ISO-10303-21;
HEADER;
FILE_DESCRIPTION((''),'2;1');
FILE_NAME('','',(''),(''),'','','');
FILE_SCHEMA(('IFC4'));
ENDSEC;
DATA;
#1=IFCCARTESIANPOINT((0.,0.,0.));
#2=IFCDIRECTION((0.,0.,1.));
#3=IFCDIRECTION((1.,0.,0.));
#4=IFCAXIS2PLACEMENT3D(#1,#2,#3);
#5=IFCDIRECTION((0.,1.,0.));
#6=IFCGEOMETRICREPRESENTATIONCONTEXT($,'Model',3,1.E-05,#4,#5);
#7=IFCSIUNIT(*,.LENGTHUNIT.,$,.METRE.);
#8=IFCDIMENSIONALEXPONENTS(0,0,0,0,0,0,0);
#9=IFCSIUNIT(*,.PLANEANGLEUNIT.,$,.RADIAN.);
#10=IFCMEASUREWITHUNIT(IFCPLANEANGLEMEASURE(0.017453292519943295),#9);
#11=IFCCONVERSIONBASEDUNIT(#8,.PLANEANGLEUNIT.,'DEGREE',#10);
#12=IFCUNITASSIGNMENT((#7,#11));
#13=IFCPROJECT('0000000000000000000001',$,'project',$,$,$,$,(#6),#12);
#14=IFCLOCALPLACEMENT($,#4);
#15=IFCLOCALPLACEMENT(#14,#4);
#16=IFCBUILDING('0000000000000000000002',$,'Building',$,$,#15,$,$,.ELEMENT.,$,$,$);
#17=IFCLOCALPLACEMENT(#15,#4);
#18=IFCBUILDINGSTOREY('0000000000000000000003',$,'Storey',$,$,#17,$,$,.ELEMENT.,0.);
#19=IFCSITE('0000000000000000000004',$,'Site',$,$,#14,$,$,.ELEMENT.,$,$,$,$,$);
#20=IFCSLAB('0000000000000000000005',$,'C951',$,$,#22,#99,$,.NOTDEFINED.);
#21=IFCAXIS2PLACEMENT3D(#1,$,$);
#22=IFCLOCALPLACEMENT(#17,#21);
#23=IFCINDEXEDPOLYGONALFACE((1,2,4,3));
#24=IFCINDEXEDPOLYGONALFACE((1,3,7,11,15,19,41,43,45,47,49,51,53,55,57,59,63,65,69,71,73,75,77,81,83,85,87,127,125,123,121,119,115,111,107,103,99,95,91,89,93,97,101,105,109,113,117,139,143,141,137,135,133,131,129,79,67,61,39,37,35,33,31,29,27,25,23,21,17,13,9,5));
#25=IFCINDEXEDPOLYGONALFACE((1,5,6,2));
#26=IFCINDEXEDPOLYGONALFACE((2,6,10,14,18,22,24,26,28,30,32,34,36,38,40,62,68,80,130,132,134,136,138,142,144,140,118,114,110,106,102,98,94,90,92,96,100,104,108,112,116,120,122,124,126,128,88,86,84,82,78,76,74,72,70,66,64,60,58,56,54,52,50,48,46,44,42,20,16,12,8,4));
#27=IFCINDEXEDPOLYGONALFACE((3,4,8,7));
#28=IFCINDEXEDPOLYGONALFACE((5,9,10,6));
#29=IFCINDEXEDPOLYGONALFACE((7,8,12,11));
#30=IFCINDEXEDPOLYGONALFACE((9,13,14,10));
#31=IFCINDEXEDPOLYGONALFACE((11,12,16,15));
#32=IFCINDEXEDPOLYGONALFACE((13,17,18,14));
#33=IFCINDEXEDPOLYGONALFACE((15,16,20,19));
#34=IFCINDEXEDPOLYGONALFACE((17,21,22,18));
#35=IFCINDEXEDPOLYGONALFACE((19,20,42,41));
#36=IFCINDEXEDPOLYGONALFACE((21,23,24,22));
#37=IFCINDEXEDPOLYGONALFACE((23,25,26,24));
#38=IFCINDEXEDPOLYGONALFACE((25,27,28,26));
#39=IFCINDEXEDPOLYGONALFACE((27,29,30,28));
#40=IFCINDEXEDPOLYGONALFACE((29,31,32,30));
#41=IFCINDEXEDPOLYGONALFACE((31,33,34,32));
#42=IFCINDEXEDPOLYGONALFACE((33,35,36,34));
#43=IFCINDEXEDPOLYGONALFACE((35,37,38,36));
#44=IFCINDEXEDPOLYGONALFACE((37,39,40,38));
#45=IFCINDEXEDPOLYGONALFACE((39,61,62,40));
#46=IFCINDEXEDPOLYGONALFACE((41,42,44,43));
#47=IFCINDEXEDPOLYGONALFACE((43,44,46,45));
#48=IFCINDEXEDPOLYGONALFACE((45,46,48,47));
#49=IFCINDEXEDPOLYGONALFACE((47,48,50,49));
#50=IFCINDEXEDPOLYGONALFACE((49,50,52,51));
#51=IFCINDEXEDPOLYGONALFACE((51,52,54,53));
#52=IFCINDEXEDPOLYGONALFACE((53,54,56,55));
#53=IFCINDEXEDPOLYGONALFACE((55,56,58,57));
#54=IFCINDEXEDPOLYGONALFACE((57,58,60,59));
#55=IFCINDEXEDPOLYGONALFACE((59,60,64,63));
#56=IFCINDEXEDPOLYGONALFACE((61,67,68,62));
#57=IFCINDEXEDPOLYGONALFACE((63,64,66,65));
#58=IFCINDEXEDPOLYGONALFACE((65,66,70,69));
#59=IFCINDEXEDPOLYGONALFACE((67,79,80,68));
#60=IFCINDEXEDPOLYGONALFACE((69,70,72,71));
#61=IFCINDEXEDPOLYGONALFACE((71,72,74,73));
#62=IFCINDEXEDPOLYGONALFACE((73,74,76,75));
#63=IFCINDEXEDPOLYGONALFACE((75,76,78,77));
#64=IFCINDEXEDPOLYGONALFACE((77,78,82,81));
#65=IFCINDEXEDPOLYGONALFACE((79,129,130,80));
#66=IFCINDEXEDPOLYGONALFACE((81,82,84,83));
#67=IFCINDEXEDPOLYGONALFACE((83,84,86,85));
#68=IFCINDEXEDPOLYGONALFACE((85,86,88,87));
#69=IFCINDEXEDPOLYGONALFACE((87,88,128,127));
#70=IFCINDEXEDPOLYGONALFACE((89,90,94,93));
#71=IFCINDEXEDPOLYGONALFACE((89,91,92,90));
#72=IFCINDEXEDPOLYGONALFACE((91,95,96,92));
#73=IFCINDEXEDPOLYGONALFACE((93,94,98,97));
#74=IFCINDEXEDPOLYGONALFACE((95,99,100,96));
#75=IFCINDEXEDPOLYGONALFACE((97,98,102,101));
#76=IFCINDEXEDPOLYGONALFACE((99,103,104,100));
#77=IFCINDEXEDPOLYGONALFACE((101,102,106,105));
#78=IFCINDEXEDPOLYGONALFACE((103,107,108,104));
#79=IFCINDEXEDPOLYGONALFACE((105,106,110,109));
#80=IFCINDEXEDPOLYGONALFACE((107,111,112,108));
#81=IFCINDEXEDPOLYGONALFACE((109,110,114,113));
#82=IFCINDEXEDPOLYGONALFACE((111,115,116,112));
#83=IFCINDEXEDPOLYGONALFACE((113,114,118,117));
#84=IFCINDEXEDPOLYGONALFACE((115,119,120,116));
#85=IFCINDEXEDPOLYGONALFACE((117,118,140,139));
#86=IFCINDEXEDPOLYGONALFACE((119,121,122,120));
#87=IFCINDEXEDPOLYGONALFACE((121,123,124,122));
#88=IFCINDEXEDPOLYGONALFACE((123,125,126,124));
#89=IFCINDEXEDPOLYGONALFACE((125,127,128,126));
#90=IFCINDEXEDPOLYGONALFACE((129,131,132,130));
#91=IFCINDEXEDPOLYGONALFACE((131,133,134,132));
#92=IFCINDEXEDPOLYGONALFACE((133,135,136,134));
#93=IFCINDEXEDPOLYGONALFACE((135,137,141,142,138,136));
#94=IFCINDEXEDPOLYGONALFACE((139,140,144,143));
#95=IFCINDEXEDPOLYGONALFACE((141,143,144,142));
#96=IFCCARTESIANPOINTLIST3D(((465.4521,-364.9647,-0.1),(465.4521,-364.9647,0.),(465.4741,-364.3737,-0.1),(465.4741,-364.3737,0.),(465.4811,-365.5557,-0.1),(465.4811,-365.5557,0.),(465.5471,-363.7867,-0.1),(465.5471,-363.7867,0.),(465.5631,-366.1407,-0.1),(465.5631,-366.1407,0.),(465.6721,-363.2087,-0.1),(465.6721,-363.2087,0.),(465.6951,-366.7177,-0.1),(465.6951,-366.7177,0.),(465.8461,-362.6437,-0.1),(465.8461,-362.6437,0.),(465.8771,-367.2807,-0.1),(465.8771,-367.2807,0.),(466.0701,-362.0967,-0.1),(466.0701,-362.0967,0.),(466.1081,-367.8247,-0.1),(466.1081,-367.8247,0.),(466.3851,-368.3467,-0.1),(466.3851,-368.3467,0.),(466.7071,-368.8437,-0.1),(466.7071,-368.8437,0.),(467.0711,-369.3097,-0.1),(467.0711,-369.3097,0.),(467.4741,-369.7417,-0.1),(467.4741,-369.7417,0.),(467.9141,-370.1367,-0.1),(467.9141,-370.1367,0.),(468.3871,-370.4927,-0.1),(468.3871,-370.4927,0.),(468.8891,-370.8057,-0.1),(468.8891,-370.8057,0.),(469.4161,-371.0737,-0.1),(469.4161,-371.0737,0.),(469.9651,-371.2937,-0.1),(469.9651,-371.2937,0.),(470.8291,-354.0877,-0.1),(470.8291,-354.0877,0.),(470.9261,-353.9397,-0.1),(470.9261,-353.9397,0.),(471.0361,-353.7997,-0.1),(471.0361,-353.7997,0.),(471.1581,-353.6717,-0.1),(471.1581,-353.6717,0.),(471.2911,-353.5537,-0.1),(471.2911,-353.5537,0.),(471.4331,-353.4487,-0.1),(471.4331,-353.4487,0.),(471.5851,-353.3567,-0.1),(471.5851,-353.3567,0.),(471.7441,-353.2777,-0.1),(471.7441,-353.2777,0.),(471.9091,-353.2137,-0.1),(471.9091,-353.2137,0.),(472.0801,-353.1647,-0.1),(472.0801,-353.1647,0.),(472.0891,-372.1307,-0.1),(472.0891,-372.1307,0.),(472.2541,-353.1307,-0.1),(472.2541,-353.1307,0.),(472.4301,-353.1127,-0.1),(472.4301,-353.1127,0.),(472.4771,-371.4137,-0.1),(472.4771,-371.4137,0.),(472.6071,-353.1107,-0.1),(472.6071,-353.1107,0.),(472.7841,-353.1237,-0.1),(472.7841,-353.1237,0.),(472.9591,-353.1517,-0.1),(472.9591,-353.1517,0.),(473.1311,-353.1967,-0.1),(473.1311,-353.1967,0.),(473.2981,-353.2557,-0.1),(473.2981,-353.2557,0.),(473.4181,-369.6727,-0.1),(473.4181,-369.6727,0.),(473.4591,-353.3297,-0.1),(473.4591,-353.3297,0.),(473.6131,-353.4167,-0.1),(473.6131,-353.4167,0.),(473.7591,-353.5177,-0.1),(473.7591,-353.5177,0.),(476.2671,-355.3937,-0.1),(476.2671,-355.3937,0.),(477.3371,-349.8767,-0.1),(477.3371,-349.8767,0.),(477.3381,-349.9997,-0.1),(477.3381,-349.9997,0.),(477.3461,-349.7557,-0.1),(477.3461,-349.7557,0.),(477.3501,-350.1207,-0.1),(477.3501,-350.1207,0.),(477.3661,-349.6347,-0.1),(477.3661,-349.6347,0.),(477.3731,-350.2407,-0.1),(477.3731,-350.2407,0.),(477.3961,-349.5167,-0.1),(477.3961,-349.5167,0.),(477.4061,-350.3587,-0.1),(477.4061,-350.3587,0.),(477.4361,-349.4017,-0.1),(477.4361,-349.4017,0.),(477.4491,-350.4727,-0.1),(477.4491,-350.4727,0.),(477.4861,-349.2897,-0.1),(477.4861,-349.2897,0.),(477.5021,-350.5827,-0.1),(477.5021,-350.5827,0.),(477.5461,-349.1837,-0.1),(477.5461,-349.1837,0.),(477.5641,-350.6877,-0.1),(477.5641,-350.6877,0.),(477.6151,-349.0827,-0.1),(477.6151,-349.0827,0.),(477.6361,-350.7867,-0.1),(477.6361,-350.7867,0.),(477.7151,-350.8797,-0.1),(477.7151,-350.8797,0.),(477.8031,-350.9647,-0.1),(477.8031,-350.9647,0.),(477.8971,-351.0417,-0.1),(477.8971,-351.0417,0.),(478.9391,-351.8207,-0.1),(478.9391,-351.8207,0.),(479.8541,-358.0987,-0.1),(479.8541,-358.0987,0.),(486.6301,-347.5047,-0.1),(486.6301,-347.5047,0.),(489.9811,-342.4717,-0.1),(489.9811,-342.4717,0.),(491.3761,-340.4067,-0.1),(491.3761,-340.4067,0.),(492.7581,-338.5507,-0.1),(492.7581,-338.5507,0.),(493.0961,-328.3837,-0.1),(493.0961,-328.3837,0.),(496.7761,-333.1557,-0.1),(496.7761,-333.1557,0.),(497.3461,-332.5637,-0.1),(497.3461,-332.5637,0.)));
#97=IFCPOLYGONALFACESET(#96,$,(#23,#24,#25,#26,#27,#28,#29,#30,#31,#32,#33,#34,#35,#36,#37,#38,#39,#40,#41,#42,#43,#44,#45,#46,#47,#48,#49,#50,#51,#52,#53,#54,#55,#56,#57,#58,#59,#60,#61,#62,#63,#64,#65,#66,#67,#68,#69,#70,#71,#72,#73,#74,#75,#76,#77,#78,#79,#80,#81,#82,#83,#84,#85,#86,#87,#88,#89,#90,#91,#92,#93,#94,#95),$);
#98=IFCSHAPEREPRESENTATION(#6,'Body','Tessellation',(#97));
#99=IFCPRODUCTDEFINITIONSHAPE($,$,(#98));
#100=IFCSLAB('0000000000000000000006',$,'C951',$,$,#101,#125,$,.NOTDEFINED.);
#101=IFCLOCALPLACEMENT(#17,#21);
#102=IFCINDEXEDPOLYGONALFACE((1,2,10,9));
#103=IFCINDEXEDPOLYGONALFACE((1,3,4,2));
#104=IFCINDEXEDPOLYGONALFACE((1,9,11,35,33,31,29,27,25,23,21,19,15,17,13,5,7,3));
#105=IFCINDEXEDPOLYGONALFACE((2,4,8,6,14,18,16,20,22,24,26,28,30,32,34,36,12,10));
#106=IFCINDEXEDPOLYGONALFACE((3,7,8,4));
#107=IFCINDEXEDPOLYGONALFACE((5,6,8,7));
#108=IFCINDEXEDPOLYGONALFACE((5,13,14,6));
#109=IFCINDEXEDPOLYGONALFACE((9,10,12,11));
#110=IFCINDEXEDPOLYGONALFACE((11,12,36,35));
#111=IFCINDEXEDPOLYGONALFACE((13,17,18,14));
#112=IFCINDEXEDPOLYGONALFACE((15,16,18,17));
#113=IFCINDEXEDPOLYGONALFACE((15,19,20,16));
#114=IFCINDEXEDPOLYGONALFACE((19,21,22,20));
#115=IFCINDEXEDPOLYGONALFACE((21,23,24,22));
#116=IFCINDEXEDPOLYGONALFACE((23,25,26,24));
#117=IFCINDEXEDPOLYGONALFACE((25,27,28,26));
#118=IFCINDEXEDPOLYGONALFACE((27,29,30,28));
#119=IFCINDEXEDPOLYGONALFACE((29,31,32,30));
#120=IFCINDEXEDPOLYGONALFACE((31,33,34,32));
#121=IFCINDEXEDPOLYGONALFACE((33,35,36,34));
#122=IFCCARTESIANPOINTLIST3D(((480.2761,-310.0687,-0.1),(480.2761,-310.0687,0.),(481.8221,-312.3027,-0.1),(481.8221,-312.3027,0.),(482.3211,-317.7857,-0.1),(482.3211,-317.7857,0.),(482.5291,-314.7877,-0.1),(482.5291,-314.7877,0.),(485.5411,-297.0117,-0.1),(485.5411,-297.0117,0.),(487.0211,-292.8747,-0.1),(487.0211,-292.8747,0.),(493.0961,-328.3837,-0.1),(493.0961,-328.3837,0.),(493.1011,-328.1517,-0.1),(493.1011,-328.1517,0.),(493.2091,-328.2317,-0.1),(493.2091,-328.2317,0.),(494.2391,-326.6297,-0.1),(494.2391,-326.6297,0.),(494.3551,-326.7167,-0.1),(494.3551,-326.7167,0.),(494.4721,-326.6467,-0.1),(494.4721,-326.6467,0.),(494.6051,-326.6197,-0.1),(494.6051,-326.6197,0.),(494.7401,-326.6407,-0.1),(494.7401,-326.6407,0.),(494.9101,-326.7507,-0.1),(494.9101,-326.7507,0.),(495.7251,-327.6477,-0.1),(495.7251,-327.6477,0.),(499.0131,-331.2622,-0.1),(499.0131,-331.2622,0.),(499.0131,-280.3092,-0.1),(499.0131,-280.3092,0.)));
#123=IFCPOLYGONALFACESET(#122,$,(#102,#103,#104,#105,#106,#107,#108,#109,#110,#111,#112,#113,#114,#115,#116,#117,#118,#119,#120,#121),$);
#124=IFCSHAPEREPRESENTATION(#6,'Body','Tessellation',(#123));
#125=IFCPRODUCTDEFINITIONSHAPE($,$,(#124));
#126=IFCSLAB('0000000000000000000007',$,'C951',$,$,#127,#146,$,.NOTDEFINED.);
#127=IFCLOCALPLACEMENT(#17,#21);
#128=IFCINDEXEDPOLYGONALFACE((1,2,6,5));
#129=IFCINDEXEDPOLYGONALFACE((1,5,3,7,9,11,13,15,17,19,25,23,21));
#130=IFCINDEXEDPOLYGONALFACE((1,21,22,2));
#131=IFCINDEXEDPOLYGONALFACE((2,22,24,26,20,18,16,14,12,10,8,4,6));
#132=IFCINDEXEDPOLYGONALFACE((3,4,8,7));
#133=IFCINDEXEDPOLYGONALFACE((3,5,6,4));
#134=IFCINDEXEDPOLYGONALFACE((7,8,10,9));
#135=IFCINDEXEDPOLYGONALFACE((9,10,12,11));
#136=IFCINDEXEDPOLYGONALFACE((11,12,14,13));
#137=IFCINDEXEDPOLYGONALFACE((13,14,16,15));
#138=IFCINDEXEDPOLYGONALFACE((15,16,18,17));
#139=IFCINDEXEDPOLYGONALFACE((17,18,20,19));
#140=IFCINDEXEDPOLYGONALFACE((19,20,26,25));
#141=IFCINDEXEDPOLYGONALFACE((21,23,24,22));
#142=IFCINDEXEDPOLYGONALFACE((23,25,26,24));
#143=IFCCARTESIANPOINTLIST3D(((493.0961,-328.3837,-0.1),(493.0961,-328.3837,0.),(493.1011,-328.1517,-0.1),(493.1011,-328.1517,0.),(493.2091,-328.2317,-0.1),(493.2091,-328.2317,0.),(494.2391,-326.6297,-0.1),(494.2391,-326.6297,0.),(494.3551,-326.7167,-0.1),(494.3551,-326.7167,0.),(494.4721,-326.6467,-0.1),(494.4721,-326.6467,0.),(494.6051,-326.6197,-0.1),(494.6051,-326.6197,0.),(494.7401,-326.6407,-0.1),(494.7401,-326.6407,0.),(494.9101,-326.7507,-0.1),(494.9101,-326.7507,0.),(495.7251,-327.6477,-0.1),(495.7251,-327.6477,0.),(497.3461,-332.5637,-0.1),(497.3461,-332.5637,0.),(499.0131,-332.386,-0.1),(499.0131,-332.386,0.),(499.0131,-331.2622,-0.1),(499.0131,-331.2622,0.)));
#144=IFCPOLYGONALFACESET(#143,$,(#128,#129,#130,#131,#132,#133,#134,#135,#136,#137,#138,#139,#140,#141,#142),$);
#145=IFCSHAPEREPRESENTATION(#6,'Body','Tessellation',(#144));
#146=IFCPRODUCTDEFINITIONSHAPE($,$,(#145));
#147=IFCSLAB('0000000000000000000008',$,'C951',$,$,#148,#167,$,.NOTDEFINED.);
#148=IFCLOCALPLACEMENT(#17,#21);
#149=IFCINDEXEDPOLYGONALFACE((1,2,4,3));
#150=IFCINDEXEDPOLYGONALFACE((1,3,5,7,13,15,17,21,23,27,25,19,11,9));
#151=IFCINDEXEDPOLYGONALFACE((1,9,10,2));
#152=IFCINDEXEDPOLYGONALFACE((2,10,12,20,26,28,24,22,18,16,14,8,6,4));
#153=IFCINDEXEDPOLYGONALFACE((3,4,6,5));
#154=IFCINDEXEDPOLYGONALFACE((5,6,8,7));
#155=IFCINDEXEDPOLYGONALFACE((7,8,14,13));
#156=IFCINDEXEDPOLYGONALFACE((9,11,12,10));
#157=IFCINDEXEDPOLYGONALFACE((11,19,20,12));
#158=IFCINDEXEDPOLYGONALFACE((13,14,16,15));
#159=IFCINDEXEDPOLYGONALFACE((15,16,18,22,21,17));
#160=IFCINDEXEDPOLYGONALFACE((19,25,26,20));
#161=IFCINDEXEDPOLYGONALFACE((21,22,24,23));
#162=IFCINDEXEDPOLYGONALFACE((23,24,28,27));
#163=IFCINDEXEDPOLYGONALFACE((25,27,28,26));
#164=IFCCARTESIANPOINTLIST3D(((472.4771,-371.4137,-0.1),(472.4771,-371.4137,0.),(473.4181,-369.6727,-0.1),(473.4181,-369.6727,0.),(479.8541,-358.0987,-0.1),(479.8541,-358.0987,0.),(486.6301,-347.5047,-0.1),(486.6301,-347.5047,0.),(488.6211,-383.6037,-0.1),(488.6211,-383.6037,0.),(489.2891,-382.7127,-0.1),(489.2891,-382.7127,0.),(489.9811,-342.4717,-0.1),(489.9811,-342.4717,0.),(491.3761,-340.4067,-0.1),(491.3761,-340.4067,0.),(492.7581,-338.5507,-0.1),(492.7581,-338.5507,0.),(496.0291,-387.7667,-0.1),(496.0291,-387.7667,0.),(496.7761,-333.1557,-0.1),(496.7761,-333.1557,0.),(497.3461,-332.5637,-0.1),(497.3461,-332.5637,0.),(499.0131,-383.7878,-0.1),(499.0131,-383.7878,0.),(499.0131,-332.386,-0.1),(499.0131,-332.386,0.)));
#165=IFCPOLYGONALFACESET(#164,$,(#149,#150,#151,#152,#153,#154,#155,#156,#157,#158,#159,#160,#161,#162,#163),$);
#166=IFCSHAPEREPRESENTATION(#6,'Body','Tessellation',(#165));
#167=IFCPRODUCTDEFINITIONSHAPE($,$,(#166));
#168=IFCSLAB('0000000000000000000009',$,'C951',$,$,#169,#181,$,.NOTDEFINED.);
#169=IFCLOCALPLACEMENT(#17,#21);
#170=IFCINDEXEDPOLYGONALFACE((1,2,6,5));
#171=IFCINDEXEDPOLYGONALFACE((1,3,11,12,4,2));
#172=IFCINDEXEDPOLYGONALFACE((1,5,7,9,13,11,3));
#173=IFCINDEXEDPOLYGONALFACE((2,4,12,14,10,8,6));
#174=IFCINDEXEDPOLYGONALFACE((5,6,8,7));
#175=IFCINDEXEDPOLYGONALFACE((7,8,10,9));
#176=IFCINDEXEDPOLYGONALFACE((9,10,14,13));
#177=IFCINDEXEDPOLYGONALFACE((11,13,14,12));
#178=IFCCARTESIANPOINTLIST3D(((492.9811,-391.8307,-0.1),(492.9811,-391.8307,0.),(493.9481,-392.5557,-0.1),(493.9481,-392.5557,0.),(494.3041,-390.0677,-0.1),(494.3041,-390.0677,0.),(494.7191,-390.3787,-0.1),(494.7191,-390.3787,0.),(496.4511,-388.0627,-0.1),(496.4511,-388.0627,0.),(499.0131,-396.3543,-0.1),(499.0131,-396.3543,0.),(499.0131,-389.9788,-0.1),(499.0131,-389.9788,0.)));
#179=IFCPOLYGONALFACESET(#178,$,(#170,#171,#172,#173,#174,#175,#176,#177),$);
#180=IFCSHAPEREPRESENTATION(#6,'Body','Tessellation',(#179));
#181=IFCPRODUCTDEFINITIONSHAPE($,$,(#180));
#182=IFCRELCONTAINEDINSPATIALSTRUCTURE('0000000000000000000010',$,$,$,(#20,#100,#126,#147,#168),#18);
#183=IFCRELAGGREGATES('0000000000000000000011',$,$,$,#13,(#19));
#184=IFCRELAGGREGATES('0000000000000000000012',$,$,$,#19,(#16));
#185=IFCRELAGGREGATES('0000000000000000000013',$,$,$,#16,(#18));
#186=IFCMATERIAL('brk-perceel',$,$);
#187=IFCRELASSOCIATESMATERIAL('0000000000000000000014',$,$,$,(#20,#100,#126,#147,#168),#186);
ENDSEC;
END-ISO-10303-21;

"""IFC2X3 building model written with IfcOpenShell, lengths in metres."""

from ifc_helpers import new_model, entity, si_unit, converted_unit, direction, frame, origin_with_axes, place, context, project, spatial, polyline, outline, extrude, material, element, save


model = new_model("IFC2X3")

# Units and contexts
model_context = context("Model", 3, precision=1e-05, world=origin_with_axes(), true_north=direction((0.0, 1.0, 0.0)))
ifc_project = project(units=[si_unit("LENGTHUNIT", "METRE"), converted_unit("PLANEANGLEUNIT", "DEGREE", entity("IfcPlaneAngleMeasure", 0.017453292519943295), si_unit("PLANEANGLEUNIT", "RADIAN"), dimensions=[0, 0, 0, 0, 0, 0, 0])], contexts=[model_context])

# Site, building, storey
site_placement = place(None, origin_with_axes())
site = spatial("IfcSite", under=ifc_project, at=site_placement, Name="Site", CompositionType="ELEMENT")
building_placement = place(site_placement, origin_with_axes())
building = spatial("IfcBuilding", under=site, at=building_placement, Name="Building", CompositionType="ELEMENT")
storey_placement = place(building_placement, origin_with_axes())
storey = spatial("IfcBuildingStorey", under=building, at=storey_placement, Name="Storey", CompositionType="ELEMENT", Elevation=0.0)

# Slabs
ifc_material = material(Name="brk-perceel")
slab_1_placement = place(storey_placement, frame((0.0, 0.0, -0.1), z_axis=(0.0, 0.0, 1.0), x_axis=(1.0, 0.0, 0.0)))
element("IfcSlab", 1, at=slab_1_placement, inside=storey, material=ifc_material, Name="C951", PredefinedType="NOTDEFINED", context=model_context, shape_type="SweptSolid", body=[
    extrude(outline(polyline([(472.0891, -372.1307), (469.9651, -371.2937), (469.4161, -371.0737), (468.8891, -370.8057), (468.3871, -370.4927), (467.9141, -370.1367), (467.4741, -369.7417), (467.0711, -369.3097), (466.7071, -368.8437), (466.3851, -368.3467), (466.1081, -367.8247), (465.8771, -367.2807), (465.6951, -366.7177), (465.5631, -366.1407), (465.4811, -365.5557), (465.4521, -364.9647), (465.4741, -364.3737), (465.5471, -363.7867), (465.6721, -363.2087), (465.8461, -362.6437), (466.0701, -362.0967), (470.8291, -354.0877), (470.9261, -353.9397), (471.0361, -353.7997), (471.1581, -353.6717), (471.2911, -353.5537), (471.4331, -353.4487), (471.5851, -353.3567), (471.7441, -353.2777), (471.9091, -353.2137), (472.0801, -353.1647), (472.2541, -353.1307), (472.4301, -353.1127), (472.6071, -353.1107), (472.7841, -353.1237), (472.9591, -353.1517), (473.1311, -353.1967), (473.2981, -353.2557), (473.4591, -353.3297), (473.6131, -353.4167), (473.7591, -353.5177), (476.2671, -355.3937), (478.9391, -351.8207), (477.8971, -351.0417), (477.8031, -350.9647), (477.7151, -350.8797), (477.6361, -350.7867), (477.5641, -350.6877), (477.5021, -350.5827), (477.4491, -350.4727), (477.4061, -350.3587), (477.3731, -350.2407), (477.3501, -350.1207), (477.3381, -349.9997), (477.3371, -349.8767), (477.3461, -349.7557), (477.3661, -349.6347), (477.3961, -349.5167), (477.4361, -349.4017), (477.4861, -349.2897), (477.5461, -349.1837), (477.6151, -349.0827), (493.0961, -328.3837), (497.3461, -332.5637), (496.7761, -333.1557), (492.7581, -338.5507), (491.3761, -340.4067), (489.9811, -342.4717), (486.6301, -347.5047), (479.8541, -358.0987), (473.4181, -369.6727), (472.4771, -371.4137), (472.0891, -372.1307)])), origin_with_axes(), (0.0, 0.0, 1.0), 0.1),
])
slab_2_placement = place(storey_placement, frame((0.0, 0.0, -0.1), z_axis=(0.0, 0.0, 1.0), x_axis=(1.0, 0.0, 0.0)))
element("IfcSlab", 2, at=slab_2_placement, inside=storey, material=ifc_material, Name="C951", PredefinedType="NOTDEFINED", context=model_context, shape_type="SweptSolid", body=[
    extrude(outline(polyline([(495.7251, -327.6477), (494.9101, -326.7507), (494.7401, -326.6407), (494.6051, -326.6197), (494.4721, -326.6467), (494.3551, -326.7167), (494.2391, -326.6297), (493.1011, -328.1517), (493.2091, -328.2317), (493.0961, -328.3837), (482.3211, -317.7857), (482.5291, -314.7877), (481.8221, -312.3027), (480.2761, -310.0687), (485.5411, -297.0117), (487.0211, -292.8747), (499.0131, -280.3092), (499.0131, -331.2622), (495.7251, -327.6477)])), origin_with_axes(), (0.0, 0.0, 1.0), 0.1),
])
slab_3_placement = place(storey_placement, frame((0.0, 0.0, -0.1), z_axis=(0.0, 0.0, 1.0), x_axis=(1.0, 0.0, 0.0)))
element("IfcSlab", 3, at=slab_3_placement, inside=storey, material=ifc_material, Name="C951", PredefinedType="NOTDEFINED", context=model_context, shape_type="SweptSolid", body=[
    extrude(outline(polyline([(497.3461, -332.5637), (493.0961, -328.3837), (493.2091, -328.2317), (493.1011, -328.1517), (494.2391, -326.6297), (494.3551, -326.7167), (494.4721, -326.6467), (494.6051, -326.6197), (494.7401, -326.6407), (494.9101, -326.7507), (495.7251, -327.6477), (499.0131, -331.2622), (499.0131, -332.386), (497.3461, -332.5637)])), origin_with_axes(), (0.0, 0.0, 1.0), 0.1),
])
slab_4_placement = place(storey_placement, frame((0.0, 0.0, -0.1), z_axis=(0.0, 0.0, 1.0), x_axis=(1.0, 0.0, 0.0)))
element("IfcSlab", 4, at=slab_4_placement, inside=storey, material=ifc_material, Name="C951", PredefinedType="NOTDEFINED", context=model_context, shape_type="SweptSolid", body=[
    extrude(outline(polyline([(496.0291, -387.7667), (489.2891, -382.7127), (488.6211, -383.6037), (472.4771, -371.4137), (473.4181, -369.6727), (479.8541, -358.0987), (486.6301, -347.5047), (489.9811, -342.4717), (491.3761, -340.4067), (492.7581, -338.5507), (496.7761, -333.1557), (497.3461, -332.5637), (499.0131, -332.386), (499.0131, -383.7878), (496.0291, -387.7667)])), origin_with_axes(), (0.0, 0.0, 1.0), 0.1),
])
slab_5_placement = place(storey_placement, frame((0.0, 0.0, -0.1), z_axis=(0.0, 0.0, 1.0), x_axis=(1.0, 0.0, 0.0)))
element("IfcSlab", 5, at=slab_5_placement, inside=storey, material=ifc_material, Name="C951", PredefinedType="NOTDEFINED", context=model_context, shape_type="SweptSolid", body=[
    extrude(outline(polyline([(493.9481, -392.5557), (492.9811, -391.8307), (494.3041, -390.0677), (494.7191, -390.3787), (496.4511, -388.0627), (499.0131, -389.9788), (499.0131, -396.3543), (493.9481, -392.5557)])), origin_with_axes(), (0.0, 0.0, 1.0), 0.1),
])

save(model, "model.ifc")
